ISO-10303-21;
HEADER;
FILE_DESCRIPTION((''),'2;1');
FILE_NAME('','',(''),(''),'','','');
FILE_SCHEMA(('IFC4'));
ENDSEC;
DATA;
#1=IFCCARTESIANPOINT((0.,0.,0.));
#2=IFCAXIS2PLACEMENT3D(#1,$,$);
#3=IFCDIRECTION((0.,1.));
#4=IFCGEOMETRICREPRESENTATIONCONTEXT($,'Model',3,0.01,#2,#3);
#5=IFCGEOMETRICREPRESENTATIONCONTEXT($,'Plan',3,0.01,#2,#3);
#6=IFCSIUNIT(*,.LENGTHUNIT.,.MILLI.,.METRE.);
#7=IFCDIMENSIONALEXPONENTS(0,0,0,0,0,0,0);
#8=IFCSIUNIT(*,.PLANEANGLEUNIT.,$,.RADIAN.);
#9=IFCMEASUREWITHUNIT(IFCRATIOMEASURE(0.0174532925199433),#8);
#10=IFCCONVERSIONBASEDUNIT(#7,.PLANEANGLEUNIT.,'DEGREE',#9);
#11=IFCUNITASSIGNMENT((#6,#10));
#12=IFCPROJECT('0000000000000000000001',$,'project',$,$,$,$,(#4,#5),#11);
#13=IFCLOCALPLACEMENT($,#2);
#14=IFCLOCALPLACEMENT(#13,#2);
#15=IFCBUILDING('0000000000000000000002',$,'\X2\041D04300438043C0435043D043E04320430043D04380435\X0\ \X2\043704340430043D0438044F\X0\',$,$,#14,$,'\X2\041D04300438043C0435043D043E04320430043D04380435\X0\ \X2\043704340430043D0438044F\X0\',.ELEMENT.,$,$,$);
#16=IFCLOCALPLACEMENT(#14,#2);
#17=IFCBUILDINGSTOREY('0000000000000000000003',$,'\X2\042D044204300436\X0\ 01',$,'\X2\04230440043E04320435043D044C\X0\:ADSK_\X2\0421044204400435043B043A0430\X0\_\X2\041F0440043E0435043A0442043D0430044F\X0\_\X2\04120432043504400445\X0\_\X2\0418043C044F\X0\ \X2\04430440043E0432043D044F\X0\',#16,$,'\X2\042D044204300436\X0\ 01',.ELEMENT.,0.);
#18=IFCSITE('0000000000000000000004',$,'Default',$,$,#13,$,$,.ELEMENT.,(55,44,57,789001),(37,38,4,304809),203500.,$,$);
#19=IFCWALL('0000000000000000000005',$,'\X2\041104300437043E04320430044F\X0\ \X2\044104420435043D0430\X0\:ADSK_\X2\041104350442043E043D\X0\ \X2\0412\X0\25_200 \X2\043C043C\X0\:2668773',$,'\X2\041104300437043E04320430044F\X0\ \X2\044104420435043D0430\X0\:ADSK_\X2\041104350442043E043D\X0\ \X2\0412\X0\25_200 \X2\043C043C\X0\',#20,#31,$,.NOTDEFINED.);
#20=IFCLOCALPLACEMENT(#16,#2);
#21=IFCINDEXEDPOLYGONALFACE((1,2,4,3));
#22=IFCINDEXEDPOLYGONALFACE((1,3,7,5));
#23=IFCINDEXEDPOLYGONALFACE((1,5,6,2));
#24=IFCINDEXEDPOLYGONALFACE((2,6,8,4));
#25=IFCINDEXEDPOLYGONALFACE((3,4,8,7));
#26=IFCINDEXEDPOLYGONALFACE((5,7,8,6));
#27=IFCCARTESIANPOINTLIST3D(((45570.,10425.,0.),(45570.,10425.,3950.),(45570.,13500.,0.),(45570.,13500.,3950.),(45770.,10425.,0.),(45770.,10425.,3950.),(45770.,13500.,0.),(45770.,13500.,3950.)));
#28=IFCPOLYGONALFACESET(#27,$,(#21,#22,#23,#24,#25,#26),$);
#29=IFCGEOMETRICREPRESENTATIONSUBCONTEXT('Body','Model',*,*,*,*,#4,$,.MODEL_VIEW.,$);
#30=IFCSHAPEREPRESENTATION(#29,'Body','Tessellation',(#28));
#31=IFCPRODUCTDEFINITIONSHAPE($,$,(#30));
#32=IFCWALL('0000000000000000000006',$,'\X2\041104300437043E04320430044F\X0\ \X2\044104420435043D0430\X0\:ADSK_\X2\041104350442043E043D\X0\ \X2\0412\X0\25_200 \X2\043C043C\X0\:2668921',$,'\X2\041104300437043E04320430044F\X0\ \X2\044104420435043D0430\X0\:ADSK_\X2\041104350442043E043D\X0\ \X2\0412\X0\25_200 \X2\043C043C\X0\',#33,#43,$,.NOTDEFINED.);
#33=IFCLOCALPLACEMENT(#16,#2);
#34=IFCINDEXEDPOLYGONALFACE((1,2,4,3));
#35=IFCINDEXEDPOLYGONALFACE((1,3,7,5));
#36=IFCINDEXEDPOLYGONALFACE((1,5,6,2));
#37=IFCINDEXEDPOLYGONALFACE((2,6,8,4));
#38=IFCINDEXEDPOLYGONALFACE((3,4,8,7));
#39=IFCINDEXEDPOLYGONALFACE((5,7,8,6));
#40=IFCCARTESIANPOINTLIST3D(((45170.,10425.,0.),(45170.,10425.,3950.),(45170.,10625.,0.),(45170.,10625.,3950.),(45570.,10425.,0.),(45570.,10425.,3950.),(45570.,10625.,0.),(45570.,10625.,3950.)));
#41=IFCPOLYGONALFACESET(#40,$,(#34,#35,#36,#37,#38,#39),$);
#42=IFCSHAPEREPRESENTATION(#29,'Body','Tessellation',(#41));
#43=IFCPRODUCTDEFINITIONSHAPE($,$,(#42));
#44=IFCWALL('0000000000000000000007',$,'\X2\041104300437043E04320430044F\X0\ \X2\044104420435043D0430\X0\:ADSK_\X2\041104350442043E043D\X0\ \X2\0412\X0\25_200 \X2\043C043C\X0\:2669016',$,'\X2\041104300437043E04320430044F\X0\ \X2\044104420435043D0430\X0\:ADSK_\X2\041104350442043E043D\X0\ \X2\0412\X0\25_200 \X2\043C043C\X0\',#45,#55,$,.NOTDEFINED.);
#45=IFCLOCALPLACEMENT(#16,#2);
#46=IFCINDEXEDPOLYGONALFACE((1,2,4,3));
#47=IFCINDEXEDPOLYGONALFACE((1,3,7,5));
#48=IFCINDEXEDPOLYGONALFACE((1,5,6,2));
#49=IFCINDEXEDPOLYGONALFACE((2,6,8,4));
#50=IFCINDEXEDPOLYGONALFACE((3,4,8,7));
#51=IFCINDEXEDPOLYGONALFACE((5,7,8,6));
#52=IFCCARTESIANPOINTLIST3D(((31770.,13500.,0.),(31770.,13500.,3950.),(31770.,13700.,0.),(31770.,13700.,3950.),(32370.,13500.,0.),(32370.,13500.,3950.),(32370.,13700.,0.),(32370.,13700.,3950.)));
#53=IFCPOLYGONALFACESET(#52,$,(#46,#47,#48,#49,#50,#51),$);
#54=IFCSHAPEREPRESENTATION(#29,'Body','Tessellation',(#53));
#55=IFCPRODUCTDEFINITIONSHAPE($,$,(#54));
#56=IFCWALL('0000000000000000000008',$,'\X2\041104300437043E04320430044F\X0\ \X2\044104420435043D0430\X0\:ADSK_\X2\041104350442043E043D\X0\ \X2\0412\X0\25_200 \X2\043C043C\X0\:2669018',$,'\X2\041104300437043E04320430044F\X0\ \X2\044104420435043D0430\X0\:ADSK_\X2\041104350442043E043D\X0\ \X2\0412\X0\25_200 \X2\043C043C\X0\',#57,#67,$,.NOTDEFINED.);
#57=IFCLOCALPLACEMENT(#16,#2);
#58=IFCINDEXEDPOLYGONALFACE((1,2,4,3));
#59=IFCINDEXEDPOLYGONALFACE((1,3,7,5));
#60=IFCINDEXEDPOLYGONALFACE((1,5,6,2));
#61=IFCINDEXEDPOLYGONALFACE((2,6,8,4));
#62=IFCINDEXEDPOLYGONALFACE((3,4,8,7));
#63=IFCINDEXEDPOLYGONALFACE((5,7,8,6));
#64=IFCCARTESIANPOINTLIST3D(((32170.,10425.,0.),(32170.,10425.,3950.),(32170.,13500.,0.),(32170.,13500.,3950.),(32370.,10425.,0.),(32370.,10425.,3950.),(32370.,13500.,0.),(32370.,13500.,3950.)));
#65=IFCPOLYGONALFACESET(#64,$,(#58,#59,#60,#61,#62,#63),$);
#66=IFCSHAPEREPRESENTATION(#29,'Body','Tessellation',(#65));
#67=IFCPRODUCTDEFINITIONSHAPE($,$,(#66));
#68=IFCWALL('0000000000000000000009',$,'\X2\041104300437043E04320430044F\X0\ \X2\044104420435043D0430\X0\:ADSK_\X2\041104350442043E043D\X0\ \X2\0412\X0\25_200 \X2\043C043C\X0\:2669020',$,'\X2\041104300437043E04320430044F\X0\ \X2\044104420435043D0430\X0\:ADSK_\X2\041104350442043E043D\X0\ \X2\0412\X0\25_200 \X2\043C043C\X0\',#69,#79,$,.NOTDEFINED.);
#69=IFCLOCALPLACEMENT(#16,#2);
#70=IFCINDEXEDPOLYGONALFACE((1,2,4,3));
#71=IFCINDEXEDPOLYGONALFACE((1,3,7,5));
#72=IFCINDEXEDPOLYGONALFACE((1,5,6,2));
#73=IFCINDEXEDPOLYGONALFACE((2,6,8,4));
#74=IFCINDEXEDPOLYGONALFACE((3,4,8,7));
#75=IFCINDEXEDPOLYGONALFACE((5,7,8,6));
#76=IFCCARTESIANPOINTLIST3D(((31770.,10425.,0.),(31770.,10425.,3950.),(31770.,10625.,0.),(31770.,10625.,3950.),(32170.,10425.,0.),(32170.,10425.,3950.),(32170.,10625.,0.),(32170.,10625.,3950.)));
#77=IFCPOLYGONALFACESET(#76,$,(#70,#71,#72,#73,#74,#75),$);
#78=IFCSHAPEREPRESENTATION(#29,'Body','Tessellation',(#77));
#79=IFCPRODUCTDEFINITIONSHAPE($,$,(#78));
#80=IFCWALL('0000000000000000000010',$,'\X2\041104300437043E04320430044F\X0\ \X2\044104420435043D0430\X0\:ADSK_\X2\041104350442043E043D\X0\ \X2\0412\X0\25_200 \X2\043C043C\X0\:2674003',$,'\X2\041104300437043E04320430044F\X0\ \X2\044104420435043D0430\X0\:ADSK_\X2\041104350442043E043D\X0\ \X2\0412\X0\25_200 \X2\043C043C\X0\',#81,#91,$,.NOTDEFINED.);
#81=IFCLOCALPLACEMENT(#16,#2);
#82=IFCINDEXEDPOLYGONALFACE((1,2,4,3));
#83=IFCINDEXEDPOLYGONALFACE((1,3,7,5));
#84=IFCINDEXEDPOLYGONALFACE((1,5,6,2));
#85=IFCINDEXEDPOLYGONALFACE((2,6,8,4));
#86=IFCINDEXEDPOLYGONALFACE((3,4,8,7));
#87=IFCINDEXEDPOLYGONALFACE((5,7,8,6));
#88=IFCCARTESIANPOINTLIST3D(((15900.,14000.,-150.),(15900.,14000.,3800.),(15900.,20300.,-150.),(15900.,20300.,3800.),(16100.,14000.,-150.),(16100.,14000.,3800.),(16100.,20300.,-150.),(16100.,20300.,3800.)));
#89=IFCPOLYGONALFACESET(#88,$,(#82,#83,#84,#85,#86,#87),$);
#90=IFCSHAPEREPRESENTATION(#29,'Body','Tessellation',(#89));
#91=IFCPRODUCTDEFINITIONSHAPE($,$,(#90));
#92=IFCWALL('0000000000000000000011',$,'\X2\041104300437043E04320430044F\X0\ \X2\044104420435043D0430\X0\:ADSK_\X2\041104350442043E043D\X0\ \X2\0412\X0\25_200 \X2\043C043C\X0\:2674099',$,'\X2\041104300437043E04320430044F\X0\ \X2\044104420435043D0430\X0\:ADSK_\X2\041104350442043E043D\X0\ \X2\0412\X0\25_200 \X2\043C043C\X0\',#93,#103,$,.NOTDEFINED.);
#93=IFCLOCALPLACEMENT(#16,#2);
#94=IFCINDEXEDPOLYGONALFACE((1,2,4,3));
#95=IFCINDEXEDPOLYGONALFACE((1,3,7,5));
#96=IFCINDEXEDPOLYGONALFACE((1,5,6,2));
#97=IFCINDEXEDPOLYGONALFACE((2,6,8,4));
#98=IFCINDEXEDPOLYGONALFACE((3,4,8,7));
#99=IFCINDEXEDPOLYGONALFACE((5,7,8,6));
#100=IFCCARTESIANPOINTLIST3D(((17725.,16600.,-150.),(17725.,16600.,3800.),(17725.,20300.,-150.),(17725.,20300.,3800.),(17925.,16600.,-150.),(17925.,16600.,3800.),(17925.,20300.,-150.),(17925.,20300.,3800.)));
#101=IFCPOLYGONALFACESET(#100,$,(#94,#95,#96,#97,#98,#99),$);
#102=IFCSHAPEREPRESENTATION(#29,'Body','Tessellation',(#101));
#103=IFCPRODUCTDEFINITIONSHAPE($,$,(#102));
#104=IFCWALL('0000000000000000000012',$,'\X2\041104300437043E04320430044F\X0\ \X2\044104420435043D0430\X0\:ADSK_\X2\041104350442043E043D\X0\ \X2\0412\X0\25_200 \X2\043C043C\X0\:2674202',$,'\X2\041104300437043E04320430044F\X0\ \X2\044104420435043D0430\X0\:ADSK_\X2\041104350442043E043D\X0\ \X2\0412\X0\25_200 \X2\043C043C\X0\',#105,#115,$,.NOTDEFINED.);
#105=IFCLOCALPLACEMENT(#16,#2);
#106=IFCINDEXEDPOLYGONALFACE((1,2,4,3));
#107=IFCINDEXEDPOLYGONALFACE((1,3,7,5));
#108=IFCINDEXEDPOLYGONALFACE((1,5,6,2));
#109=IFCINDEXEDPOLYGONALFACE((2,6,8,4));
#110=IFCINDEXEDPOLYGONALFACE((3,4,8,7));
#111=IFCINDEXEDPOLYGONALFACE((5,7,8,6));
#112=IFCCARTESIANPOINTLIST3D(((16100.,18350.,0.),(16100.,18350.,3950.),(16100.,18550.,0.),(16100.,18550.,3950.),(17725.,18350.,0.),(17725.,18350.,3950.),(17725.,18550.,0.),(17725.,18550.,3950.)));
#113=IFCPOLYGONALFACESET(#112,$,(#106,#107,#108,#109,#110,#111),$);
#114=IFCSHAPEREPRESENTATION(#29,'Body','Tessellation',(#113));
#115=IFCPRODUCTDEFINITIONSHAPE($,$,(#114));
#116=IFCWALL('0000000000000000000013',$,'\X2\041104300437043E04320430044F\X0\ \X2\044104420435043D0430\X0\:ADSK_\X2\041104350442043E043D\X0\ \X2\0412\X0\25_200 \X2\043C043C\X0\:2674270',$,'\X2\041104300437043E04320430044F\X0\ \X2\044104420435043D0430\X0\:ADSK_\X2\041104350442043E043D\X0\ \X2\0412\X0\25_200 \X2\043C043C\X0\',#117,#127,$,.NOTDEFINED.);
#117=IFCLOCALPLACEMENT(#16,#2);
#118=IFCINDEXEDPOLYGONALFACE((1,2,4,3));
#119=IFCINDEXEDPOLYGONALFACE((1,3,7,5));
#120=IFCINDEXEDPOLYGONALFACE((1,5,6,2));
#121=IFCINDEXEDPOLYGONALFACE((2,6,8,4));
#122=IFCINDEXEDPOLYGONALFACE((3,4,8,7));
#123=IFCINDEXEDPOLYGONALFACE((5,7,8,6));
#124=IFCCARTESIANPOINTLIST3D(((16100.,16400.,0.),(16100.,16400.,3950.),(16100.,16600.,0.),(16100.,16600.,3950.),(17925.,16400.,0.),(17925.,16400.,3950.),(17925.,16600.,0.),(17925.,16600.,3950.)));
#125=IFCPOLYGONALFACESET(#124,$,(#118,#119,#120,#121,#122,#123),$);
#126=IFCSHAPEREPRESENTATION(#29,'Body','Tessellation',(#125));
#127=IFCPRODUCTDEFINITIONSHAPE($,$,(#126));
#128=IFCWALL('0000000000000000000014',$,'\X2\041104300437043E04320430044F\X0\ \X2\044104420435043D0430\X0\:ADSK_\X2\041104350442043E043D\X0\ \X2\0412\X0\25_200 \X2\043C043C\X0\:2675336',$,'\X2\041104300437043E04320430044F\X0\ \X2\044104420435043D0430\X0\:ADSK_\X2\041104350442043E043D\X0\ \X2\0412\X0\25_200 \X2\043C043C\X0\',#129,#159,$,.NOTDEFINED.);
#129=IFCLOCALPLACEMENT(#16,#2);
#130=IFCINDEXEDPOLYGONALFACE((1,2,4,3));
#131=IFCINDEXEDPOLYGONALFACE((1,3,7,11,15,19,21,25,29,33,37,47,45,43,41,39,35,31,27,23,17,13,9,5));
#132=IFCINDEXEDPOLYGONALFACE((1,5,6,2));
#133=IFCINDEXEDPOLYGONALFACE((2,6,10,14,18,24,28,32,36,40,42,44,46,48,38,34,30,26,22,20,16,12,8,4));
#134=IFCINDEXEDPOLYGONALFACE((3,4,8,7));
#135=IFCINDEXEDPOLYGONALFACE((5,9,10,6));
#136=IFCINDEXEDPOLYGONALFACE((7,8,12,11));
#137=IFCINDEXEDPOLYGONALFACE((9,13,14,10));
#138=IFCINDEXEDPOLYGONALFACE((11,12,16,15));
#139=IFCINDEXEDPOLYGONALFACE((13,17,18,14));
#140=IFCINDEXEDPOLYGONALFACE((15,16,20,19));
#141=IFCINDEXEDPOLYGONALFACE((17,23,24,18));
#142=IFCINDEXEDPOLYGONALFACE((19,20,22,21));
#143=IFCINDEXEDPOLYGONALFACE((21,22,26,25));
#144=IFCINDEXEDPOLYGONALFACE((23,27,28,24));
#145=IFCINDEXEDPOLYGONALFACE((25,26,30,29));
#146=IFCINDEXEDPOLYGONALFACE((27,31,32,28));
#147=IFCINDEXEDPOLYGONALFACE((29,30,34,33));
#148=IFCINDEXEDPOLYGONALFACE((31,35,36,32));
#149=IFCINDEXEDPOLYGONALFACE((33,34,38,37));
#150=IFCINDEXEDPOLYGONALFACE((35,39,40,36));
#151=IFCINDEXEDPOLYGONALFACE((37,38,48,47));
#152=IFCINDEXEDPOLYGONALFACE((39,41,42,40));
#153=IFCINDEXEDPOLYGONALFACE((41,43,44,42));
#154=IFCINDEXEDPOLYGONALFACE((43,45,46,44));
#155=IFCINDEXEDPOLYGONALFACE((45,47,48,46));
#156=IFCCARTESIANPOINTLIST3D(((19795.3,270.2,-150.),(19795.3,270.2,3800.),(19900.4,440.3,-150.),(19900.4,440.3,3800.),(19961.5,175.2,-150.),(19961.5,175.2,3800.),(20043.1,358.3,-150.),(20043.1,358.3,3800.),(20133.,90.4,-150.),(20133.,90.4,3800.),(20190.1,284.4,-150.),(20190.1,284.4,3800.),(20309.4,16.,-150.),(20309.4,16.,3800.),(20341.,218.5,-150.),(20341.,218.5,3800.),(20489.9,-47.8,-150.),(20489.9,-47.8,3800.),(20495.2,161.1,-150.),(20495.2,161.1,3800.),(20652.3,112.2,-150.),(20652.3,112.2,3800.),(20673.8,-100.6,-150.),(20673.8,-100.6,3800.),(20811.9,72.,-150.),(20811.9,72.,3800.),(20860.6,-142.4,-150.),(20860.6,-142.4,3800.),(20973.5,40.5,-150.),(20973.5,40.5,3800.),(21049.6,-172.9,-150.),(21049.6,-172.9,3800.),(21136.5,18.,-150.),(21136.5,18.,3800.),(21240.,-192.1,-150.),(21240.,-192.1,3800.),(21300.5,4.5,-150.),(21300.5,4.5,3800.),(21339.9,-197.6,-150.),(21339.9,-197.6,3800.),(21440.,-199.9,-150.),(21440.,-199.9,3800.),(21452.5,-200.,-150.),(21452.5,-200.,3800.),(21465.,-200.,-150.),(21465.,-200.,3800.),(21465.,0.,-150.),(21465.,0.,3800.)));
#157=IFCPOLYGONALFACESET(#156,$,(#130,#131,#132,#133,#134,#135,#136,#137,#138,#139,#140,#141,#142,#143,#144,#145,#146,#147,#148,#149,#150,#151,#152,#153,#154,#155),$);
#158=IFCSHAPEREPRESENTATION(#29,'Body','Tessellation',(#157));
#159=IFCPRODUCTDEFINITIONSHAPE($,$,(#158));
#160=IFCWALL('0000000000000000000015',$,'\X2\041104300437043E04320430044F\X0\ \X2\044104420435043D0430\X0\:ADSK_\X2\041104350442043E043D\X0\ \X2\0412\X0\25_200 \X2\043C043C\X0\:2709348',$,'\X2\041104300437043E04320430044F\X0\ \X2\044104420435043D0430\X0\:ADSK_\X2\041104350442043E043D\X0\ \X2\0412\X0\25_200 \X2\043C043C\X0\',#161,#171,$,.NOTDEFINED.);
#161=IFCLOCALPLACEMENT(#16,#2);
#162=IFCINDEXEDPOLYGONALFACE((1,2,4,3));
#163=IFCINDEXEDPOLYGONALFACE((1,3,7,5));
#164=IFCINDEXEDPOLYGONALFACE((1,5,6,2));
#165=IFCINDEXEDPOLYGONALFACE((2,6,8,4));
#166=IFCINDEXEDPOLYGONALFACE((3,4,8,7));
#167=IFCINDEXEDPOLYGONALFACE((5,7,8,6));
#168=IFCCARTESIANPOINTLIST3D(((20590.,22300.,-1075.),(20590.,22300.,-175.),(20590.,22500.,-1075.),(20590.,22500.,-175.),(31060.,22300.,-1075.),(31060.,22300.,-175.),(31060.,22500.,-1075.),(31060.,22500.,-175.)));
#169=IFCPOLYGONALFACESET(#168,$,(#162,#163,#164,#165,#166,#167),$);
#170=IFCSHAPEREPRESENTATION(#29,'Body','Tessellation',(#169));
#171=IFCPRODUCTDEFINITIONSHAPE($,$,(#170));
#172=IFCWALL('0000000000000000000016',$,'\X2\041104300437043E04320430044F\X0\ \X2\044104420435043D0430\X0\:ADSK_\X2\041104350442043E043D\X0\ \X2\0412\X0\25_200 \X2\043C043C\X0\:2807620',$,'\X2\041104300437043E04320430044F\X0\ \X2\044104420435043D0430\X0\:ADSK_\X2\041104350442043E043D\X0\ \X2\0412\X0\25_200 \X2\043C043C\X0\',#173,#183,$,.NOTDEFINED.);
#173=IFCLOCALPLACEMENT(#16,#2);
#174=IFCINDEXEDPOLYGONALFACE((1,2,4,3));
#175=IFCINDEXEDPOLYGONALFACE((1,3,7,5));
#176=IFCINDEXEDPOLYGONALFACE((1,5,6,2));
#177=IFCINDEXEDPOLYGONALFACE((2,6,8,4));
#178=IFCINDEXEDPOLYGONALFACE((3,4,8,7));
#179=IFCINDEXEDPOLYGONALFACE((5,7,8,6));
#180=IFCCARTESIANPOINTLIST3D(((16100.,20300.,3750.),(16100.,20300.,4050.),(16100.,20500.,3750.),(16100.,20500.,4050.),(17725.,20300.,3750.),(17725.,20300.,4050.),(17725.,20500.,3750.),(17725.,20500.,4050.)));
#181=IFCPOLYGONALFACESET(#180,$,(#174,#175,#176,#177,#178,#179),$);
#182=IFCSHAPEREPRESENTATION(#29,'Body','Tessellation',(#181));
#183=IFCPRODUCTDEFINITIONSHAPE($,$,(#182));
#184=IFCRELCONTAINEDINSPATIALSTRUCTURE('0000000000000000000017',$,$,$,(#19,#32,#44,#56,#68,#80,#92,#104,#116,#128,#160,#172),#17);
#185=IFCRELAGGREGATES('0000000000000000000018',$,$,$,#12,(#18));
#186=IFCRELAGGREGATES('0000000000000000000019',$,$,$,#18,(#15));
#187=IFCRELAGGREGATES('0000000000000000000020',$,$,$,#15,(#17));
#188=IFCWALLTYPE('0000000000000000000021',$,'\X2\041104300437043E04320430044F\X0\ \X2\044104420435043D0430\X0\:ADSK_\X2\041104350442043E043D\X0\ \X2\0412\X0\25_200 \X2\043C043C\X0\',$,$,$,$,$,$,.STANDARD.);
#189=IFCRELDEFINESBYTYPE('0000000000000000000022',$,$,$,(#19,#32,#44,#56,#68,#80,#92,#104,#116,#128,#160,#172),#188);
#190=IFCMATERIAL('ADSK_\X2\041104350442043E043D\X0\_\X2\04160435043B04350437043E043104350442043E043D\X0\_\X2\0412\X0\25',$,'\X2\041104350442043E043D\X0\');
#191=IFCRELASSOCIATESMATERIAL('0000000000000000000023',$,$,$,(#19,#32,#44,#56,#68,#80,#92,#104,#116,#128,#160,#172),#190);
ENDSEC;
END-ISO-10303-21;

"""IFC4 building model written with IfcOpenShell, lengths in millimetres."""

from ifc_helpers import new_model, entity, si_unit, converted_unit, direction, frame, origin, place, context, subcontext, project, spatial, indexed_curve, outline, extrude, material, type_object, element, save


model = new_model("IFC4")

# Units and contexts
model_context = context("Model", 3, precision=0.01, world=origin(), true_north=direction((0.0, 1.0)))
plan_context = context("Plan", 3, precision=0.01, world=origin(), true_north=direction((0.0, 1.0)))
body_context = subcontext(model_context, "Body", "Model", "MODEL_VIEW")
ifc_project = project(units=[si_unit("LENGTHUNIT", "METRE", prefix="MILLI"), converted_unit("PLANEANGLEUNIT", "DEGREE", entity("IfcRatioMeasure", 0.0174532925199433), si_unit("PLANEANGLEUNIT", "RADIAN"), dimensions=[0, 0, 0, 0, 0, 0, 0])], contexts=[model_context, plan_context])

# Site, building, storey
site_placement = place(None, origin())
site = spatial("IfcSite", under=ifc_project, at=site_placement, Name="Default", CompositionType="ELEMENT", RefLatitude=(55, 44, 57, 789001), RefLongitude=(37, 38, 4, 304809), RefElevation=203500.0)
building_placement = place(site_placement, origin())
building = spatial("IfcBuilding", under=site, at=building_placement, Name="Наименование здания", LongName="Наименование здания", CompositionType="ELEMENT")
storey_placement = place(building_placement, origin())
storey = spatial("IfcBuildingStorey", under=building, at=storey_placement, Name="Этаж 01", ObjectType="Уровень:ADSK_Стрелка_Проектная_Вверх_Имя уровня", LongName="Этаж 01", CompositionType="ELEMENT", Elevation=0.0)

# Walls
ifc_material = material(Name="ADSK_Бетон_Железобетон_В25", Category="Бетон")
wall_type_1 = type_object("IfcWallType", Name="Базовая стена:ADSK_Бетон В25_200 мм", PredefinedType="STANDARD")
wall_1_placement = place(storey_placement, frame((45670.0, 13500.0, 0.0), z_axis=(0.0, 0.0, 1.0), x_axis=(0.0, -1.0, 0.0)))
element("IfcWall", 1, at=wall_1_placement, inside=storey, type_object=wall_type_1, material=ifc_material, Name="Базовая стена:ADSK_Бетон В25_200 мм:2668773", ObjectType="Базовая стена:ADSK_Бетон В25_200 мм", PredefinedType="NOTDEFINED", context=body_context, shape_type="SweptSolid", body=[
    extrude(outline(indexed_curve([(3075.0, 100.0), (0.0, 100.0), (0.0, -100.0), (3075.0, -100.0), (3075.0, 100.0)], self_intersect=False)), origin(), (0.0, 0.0, 1.0), 3950.0),
])
wall_2_placement = place(storey_placement, frame((45570.0, 10525.0, 0.0), z_axis=(0.0, 0.0, 1.0), x_axis=(-1.0, 0.0, 0.0)))
element("IfcWall", 2, at=wall_2_placement, inside=storey, type_object=wall_type_1, material=ifc_material, Name="Базовая стена:ADSK_Бетон В25_200 мм:2668921", ObjectType="Базовая стена:ADSK_Бетон В25_200 мм", PredefinedType="NOTDEFINED", context=body_context, shape_type="SweptSolid", body=[
    extrude(outline(indexed_curve([(400.0, 100.0), (0.0, 100.0), (0.0, -100.0), (400.0, -100.0), (400.0, 100.0)], self_intersect=False)), origin(), (0.0, 0.0, 1.0), 3950.0),
])
wall_3_placement = place(storey_placement, frame((31770.0, 13600.0, 0.0)))
element("IfcWall", 3, at=wall_3_placement, inside=storey, type_object=wall_type_1, material=ifc_material, Name="Базовая стена:ADSK_Бетон В25_200 мм:2669016", ObjectType="Базовая стена:ADSK_Бетон В25_200 мм", PredefinedType="NOTDEFINED", context=body_context, shape_type="SweptSolid", body=[
    extrude(outline(indexed_curve([(600.0, 100.0), (0.0, 100.0), (0.0, -100.0), (600.0, -100.0), (600.0, 100.0)], self_intersect=False)), origin(), (0.0, 0.0, 1.0), 3950.0),
])
wall_4_placement = place(storey_placement, frame((32270.0, 13500.0, 0.0), z_axis=(0.0, 0.0, 1.0), x_axis=(0.0, -1.0, 0.0)))
element("IfcWall", 4, at=wall_4_placement, inside=storey, type_object=wall_type_1, material=ifc_material, Name="Базовая стена:ADSK_Бетон В25_200 мм:2669018", ObjectType="Базовая стена:ADSK_Бетон В25_200 мм", PredefinedType="NOTDEFINED", context=body_context, shape_type="SweptSolid", body=[
    extrude(outline(indexed_curve([(3075.0, 100.0), (0.0, 100.0), (0.0, -100.0), (3075.0, -100.0), (3075.0, 100.0)], self_intersect=False)), origin(), (0.0, 0.0, 1.0), 3950.0),
])
wall_5_placement = place(storey_placement, frame((32170.0, 10525.0, 0.0), z_axis=(0.0, 0.0, 1.0), x_axis=(-1.0, 0.0, 0.0)))
element("IfcWall", 5, at=wall_5_placement, inside=storey, type_object=wall_type_1, material=ifc_material, Name="Базовая стена:ADSK_Бетон В25_200 мм:2669020", ObjectType="Базовая стена:ADSK_Бетон В25_200 мм", PredefinedType="NOTDEFINED", context=body_context, shape_type="SweptSolid", body=[
    extrude(outline(indexed_curve([(400.0, 100.0), (0.0, 100.0), (0.0, -100.0), (400.0, -100.0), (400.0, 100.0)], self_intersect=False)), origin(), (0.0, 0.0, 1.0), 3950.0),
])
wall_6_placement = place(storey_placement, frame((16000.0, 20300.0, -150.0), z_axis=(0.0, 0.0, 1.0), x_axis=(0.0, -1.0, 0.0)))
element("IfcWall", 6, at=wall_6_placement, inside=storey, type_object=wall_type_1, material=ifc_material, Name="Базовая стена:ADSK_Бетон В25_200 мм:2674003", ObjectType="Базовая стена:ADSK_Бетон В25_200 мм", PredefinedType="NOTDEFINED", context=body_context, shape_type="SweptSolid", body=[
    extrude(outline(indexed_curve([(6300.0, 100.0), (0.0, 100.0), (0.0, -100.0), (6300.0, -100.0), (6300.0, 100.0)], self_intersect=False)), origin(), (0.0, 0.0, 1.0), 3950.0),
])
wall_7_placement = place(storey_placement, frame((17825.0, 20300.0, -150.0), z_axis=(0.0, 0.0, 1.0), x_axis=(0.0, -1.0, 0.0)))
element("IfcWall", 7, at=wall_7_placement, inside=storey, type_object=wall_type_1, material=ifc_material, Name="Базовая стена:ADSK_Бетон В25_200 мм:2674099", ObjectType="Базовая стена:ADSK_Бетон В25_200 мм", PredefinedType="NOTDEFINED", context=body_context, shape_type="SweptSolid", body=[
    extrude(outline(indexed_curve([(3700.0, 100.0), (0.0, 100.0), (0.0, -100.0), (3700.0, -100.0), (3700.0, 100.0)], self_intersect=False)), origin(), (0.0, 0.0, 1.0), 3950.0),
])
wall_8_placement = place(storey_placement, frame((17725.0, 18450.0, 0.0), z_axis=(0.0, 0.0, 1.0), x_axis=(-1.0, 0.0, 0.0)))
element("IfcWall", 8, at=wall_8_placement, inside=storey, type_object=wall_type_1, material=ifc_material, Name="Базовая стена:ADSK_Бетон В25_200 мм:2674202", ObjectType="Базовая стена:ADSK_Бетон В25_200 мм", PredefinedType="NOTDEFINED", context=body_context, shape_type="SweptSolid", body=[
    extrude(outline(indexed_curve([(1625.0, 100.0), (0.0, 100.0), (0.0, -100.0), (1625.0, -100.0), (1625.0, 100.0)], self_intersect=False)), origin(), (0.0, 0.0, 1.0), 3950.0),
])
wall_9_placement = place(storey_placement, frame((17925.0, 16500.0, 0.0), z_axis=(0.0, 0.0, 1.0), x_axis=(-1.0, 0.0, 0.0)))
element("IfcWall", 9, at=wall_9_placement, inside=storey, type_object=wall_type_1, material=ifc_material, Name="Базовая стена:ADSK_Бетон В25_200 мм:2674270", ObjectType="Базовая стена:ADSK_Бетон В25_200 мм", PredefinedType="NOTDEFINED", context=body_context, shape_type="SweptSolid", body=[
    extrude(outline(indexed_curve([(1825.0, 100.0), (0.0, 100.0), (0.0, -100.0), (1825.0, -100.0), (1825.0, 100.0)], self_intersect=False)), origin(), (0.0, 0.0, 1.0), 3950.0),
])
wall_10_placement = place(storey_placement, frame((21465.0, -100.0, -150.0)))
element("IfcWall", 10, at=wall_10_placement, inside=storey, type_object=wall_type_1, material=ifc_material, Name="Базовая стена:ADSK_Бетон В25_200 мм:2675336", ObjectType="Базовая стена:ADSK_Бетон В25_200 мм", PredefinedType="NOTDEFINED", context=body_context, shape_type="SweptSolid", body=[
    extrude(outline(indexed_curve([(-1669.7, 370.2), (-1503.5, 275.2), (-1332.0, 190.4), (-1155.6, 116.0), (-975.1, 52.2), (-791.2, -0.6), (-604.4, -42.4), (-415.4, -72.9), (-225.0, -92.1), (-125.1, -97.6), (-25.0, -99.9), (-12.5, -100.0), (0.0, -100.0), (0.0, 100.0), (-164.5, 104.5), (-328.5, 118.0), (-491.5, 140.5), (-653.1, 172.0), (-812.7, 212.2), (-969.8, 261.1), (-1124.0, 318.5), (-1274.9, 384.4), (-1421.9, 458.3), (-1564.6, 540.3), (-1669.7, 370.2)], self_intersect=False)), origin(), (0.0, 0.0, 1.0), 3950.0),
])
wall_11_placement = place(storey_placement, frame((20590.0, 22400.0, -1075.0)))
element("IfcWall", 11, at=wall_11_placement, inside=storey, type_object=wall_type_1, material=ifc_material, Name="Базовая стена:ADSK_Бетон В25_200 мм:2709348", ObjectType="Базовая стена:ADSK_Бетон В25_200 мм", PredefinedType="NOTDEFINED", context=body_context, shape_type="SweptSolid", body=[
    extrude(outline(indexed_curve([(10470.0, 100.0), (0.0, 100.0), (0.0, -100.0), (10470.0, -100.0), (10470.0, 100.0)], self_intersect=False)), origin(), (0.0, 0.0, 1.0), 900.0),
])
wall_12_placement = place(storey_placement, frame((16100.0, 20400.0, 3750.0)))
element("IfcWall", 12, at=wall_12_placement, inside=storey, type_object=wall_type_1, material=ifc_material, Name="Базовая стена:ADSK_Бетон В25_200 мм:2807620", ObjectType="Базовая стена:ADSK_Бетон В25_200 мм", PredefinedType="NOTDEFINED", context=body_context, shape_type="SweptSolid", body=[
    extrude(outline(indexed_curve([(1625.0, 100.0), (0.0, 100.0), (0.0, -100.0), (1625.0, -100.0), (1625.0, 100.0)], self_intersect=False)), origin(), (0.0, 0.0, 1.0), 300.0),
])

save(model, "model.ifc")
